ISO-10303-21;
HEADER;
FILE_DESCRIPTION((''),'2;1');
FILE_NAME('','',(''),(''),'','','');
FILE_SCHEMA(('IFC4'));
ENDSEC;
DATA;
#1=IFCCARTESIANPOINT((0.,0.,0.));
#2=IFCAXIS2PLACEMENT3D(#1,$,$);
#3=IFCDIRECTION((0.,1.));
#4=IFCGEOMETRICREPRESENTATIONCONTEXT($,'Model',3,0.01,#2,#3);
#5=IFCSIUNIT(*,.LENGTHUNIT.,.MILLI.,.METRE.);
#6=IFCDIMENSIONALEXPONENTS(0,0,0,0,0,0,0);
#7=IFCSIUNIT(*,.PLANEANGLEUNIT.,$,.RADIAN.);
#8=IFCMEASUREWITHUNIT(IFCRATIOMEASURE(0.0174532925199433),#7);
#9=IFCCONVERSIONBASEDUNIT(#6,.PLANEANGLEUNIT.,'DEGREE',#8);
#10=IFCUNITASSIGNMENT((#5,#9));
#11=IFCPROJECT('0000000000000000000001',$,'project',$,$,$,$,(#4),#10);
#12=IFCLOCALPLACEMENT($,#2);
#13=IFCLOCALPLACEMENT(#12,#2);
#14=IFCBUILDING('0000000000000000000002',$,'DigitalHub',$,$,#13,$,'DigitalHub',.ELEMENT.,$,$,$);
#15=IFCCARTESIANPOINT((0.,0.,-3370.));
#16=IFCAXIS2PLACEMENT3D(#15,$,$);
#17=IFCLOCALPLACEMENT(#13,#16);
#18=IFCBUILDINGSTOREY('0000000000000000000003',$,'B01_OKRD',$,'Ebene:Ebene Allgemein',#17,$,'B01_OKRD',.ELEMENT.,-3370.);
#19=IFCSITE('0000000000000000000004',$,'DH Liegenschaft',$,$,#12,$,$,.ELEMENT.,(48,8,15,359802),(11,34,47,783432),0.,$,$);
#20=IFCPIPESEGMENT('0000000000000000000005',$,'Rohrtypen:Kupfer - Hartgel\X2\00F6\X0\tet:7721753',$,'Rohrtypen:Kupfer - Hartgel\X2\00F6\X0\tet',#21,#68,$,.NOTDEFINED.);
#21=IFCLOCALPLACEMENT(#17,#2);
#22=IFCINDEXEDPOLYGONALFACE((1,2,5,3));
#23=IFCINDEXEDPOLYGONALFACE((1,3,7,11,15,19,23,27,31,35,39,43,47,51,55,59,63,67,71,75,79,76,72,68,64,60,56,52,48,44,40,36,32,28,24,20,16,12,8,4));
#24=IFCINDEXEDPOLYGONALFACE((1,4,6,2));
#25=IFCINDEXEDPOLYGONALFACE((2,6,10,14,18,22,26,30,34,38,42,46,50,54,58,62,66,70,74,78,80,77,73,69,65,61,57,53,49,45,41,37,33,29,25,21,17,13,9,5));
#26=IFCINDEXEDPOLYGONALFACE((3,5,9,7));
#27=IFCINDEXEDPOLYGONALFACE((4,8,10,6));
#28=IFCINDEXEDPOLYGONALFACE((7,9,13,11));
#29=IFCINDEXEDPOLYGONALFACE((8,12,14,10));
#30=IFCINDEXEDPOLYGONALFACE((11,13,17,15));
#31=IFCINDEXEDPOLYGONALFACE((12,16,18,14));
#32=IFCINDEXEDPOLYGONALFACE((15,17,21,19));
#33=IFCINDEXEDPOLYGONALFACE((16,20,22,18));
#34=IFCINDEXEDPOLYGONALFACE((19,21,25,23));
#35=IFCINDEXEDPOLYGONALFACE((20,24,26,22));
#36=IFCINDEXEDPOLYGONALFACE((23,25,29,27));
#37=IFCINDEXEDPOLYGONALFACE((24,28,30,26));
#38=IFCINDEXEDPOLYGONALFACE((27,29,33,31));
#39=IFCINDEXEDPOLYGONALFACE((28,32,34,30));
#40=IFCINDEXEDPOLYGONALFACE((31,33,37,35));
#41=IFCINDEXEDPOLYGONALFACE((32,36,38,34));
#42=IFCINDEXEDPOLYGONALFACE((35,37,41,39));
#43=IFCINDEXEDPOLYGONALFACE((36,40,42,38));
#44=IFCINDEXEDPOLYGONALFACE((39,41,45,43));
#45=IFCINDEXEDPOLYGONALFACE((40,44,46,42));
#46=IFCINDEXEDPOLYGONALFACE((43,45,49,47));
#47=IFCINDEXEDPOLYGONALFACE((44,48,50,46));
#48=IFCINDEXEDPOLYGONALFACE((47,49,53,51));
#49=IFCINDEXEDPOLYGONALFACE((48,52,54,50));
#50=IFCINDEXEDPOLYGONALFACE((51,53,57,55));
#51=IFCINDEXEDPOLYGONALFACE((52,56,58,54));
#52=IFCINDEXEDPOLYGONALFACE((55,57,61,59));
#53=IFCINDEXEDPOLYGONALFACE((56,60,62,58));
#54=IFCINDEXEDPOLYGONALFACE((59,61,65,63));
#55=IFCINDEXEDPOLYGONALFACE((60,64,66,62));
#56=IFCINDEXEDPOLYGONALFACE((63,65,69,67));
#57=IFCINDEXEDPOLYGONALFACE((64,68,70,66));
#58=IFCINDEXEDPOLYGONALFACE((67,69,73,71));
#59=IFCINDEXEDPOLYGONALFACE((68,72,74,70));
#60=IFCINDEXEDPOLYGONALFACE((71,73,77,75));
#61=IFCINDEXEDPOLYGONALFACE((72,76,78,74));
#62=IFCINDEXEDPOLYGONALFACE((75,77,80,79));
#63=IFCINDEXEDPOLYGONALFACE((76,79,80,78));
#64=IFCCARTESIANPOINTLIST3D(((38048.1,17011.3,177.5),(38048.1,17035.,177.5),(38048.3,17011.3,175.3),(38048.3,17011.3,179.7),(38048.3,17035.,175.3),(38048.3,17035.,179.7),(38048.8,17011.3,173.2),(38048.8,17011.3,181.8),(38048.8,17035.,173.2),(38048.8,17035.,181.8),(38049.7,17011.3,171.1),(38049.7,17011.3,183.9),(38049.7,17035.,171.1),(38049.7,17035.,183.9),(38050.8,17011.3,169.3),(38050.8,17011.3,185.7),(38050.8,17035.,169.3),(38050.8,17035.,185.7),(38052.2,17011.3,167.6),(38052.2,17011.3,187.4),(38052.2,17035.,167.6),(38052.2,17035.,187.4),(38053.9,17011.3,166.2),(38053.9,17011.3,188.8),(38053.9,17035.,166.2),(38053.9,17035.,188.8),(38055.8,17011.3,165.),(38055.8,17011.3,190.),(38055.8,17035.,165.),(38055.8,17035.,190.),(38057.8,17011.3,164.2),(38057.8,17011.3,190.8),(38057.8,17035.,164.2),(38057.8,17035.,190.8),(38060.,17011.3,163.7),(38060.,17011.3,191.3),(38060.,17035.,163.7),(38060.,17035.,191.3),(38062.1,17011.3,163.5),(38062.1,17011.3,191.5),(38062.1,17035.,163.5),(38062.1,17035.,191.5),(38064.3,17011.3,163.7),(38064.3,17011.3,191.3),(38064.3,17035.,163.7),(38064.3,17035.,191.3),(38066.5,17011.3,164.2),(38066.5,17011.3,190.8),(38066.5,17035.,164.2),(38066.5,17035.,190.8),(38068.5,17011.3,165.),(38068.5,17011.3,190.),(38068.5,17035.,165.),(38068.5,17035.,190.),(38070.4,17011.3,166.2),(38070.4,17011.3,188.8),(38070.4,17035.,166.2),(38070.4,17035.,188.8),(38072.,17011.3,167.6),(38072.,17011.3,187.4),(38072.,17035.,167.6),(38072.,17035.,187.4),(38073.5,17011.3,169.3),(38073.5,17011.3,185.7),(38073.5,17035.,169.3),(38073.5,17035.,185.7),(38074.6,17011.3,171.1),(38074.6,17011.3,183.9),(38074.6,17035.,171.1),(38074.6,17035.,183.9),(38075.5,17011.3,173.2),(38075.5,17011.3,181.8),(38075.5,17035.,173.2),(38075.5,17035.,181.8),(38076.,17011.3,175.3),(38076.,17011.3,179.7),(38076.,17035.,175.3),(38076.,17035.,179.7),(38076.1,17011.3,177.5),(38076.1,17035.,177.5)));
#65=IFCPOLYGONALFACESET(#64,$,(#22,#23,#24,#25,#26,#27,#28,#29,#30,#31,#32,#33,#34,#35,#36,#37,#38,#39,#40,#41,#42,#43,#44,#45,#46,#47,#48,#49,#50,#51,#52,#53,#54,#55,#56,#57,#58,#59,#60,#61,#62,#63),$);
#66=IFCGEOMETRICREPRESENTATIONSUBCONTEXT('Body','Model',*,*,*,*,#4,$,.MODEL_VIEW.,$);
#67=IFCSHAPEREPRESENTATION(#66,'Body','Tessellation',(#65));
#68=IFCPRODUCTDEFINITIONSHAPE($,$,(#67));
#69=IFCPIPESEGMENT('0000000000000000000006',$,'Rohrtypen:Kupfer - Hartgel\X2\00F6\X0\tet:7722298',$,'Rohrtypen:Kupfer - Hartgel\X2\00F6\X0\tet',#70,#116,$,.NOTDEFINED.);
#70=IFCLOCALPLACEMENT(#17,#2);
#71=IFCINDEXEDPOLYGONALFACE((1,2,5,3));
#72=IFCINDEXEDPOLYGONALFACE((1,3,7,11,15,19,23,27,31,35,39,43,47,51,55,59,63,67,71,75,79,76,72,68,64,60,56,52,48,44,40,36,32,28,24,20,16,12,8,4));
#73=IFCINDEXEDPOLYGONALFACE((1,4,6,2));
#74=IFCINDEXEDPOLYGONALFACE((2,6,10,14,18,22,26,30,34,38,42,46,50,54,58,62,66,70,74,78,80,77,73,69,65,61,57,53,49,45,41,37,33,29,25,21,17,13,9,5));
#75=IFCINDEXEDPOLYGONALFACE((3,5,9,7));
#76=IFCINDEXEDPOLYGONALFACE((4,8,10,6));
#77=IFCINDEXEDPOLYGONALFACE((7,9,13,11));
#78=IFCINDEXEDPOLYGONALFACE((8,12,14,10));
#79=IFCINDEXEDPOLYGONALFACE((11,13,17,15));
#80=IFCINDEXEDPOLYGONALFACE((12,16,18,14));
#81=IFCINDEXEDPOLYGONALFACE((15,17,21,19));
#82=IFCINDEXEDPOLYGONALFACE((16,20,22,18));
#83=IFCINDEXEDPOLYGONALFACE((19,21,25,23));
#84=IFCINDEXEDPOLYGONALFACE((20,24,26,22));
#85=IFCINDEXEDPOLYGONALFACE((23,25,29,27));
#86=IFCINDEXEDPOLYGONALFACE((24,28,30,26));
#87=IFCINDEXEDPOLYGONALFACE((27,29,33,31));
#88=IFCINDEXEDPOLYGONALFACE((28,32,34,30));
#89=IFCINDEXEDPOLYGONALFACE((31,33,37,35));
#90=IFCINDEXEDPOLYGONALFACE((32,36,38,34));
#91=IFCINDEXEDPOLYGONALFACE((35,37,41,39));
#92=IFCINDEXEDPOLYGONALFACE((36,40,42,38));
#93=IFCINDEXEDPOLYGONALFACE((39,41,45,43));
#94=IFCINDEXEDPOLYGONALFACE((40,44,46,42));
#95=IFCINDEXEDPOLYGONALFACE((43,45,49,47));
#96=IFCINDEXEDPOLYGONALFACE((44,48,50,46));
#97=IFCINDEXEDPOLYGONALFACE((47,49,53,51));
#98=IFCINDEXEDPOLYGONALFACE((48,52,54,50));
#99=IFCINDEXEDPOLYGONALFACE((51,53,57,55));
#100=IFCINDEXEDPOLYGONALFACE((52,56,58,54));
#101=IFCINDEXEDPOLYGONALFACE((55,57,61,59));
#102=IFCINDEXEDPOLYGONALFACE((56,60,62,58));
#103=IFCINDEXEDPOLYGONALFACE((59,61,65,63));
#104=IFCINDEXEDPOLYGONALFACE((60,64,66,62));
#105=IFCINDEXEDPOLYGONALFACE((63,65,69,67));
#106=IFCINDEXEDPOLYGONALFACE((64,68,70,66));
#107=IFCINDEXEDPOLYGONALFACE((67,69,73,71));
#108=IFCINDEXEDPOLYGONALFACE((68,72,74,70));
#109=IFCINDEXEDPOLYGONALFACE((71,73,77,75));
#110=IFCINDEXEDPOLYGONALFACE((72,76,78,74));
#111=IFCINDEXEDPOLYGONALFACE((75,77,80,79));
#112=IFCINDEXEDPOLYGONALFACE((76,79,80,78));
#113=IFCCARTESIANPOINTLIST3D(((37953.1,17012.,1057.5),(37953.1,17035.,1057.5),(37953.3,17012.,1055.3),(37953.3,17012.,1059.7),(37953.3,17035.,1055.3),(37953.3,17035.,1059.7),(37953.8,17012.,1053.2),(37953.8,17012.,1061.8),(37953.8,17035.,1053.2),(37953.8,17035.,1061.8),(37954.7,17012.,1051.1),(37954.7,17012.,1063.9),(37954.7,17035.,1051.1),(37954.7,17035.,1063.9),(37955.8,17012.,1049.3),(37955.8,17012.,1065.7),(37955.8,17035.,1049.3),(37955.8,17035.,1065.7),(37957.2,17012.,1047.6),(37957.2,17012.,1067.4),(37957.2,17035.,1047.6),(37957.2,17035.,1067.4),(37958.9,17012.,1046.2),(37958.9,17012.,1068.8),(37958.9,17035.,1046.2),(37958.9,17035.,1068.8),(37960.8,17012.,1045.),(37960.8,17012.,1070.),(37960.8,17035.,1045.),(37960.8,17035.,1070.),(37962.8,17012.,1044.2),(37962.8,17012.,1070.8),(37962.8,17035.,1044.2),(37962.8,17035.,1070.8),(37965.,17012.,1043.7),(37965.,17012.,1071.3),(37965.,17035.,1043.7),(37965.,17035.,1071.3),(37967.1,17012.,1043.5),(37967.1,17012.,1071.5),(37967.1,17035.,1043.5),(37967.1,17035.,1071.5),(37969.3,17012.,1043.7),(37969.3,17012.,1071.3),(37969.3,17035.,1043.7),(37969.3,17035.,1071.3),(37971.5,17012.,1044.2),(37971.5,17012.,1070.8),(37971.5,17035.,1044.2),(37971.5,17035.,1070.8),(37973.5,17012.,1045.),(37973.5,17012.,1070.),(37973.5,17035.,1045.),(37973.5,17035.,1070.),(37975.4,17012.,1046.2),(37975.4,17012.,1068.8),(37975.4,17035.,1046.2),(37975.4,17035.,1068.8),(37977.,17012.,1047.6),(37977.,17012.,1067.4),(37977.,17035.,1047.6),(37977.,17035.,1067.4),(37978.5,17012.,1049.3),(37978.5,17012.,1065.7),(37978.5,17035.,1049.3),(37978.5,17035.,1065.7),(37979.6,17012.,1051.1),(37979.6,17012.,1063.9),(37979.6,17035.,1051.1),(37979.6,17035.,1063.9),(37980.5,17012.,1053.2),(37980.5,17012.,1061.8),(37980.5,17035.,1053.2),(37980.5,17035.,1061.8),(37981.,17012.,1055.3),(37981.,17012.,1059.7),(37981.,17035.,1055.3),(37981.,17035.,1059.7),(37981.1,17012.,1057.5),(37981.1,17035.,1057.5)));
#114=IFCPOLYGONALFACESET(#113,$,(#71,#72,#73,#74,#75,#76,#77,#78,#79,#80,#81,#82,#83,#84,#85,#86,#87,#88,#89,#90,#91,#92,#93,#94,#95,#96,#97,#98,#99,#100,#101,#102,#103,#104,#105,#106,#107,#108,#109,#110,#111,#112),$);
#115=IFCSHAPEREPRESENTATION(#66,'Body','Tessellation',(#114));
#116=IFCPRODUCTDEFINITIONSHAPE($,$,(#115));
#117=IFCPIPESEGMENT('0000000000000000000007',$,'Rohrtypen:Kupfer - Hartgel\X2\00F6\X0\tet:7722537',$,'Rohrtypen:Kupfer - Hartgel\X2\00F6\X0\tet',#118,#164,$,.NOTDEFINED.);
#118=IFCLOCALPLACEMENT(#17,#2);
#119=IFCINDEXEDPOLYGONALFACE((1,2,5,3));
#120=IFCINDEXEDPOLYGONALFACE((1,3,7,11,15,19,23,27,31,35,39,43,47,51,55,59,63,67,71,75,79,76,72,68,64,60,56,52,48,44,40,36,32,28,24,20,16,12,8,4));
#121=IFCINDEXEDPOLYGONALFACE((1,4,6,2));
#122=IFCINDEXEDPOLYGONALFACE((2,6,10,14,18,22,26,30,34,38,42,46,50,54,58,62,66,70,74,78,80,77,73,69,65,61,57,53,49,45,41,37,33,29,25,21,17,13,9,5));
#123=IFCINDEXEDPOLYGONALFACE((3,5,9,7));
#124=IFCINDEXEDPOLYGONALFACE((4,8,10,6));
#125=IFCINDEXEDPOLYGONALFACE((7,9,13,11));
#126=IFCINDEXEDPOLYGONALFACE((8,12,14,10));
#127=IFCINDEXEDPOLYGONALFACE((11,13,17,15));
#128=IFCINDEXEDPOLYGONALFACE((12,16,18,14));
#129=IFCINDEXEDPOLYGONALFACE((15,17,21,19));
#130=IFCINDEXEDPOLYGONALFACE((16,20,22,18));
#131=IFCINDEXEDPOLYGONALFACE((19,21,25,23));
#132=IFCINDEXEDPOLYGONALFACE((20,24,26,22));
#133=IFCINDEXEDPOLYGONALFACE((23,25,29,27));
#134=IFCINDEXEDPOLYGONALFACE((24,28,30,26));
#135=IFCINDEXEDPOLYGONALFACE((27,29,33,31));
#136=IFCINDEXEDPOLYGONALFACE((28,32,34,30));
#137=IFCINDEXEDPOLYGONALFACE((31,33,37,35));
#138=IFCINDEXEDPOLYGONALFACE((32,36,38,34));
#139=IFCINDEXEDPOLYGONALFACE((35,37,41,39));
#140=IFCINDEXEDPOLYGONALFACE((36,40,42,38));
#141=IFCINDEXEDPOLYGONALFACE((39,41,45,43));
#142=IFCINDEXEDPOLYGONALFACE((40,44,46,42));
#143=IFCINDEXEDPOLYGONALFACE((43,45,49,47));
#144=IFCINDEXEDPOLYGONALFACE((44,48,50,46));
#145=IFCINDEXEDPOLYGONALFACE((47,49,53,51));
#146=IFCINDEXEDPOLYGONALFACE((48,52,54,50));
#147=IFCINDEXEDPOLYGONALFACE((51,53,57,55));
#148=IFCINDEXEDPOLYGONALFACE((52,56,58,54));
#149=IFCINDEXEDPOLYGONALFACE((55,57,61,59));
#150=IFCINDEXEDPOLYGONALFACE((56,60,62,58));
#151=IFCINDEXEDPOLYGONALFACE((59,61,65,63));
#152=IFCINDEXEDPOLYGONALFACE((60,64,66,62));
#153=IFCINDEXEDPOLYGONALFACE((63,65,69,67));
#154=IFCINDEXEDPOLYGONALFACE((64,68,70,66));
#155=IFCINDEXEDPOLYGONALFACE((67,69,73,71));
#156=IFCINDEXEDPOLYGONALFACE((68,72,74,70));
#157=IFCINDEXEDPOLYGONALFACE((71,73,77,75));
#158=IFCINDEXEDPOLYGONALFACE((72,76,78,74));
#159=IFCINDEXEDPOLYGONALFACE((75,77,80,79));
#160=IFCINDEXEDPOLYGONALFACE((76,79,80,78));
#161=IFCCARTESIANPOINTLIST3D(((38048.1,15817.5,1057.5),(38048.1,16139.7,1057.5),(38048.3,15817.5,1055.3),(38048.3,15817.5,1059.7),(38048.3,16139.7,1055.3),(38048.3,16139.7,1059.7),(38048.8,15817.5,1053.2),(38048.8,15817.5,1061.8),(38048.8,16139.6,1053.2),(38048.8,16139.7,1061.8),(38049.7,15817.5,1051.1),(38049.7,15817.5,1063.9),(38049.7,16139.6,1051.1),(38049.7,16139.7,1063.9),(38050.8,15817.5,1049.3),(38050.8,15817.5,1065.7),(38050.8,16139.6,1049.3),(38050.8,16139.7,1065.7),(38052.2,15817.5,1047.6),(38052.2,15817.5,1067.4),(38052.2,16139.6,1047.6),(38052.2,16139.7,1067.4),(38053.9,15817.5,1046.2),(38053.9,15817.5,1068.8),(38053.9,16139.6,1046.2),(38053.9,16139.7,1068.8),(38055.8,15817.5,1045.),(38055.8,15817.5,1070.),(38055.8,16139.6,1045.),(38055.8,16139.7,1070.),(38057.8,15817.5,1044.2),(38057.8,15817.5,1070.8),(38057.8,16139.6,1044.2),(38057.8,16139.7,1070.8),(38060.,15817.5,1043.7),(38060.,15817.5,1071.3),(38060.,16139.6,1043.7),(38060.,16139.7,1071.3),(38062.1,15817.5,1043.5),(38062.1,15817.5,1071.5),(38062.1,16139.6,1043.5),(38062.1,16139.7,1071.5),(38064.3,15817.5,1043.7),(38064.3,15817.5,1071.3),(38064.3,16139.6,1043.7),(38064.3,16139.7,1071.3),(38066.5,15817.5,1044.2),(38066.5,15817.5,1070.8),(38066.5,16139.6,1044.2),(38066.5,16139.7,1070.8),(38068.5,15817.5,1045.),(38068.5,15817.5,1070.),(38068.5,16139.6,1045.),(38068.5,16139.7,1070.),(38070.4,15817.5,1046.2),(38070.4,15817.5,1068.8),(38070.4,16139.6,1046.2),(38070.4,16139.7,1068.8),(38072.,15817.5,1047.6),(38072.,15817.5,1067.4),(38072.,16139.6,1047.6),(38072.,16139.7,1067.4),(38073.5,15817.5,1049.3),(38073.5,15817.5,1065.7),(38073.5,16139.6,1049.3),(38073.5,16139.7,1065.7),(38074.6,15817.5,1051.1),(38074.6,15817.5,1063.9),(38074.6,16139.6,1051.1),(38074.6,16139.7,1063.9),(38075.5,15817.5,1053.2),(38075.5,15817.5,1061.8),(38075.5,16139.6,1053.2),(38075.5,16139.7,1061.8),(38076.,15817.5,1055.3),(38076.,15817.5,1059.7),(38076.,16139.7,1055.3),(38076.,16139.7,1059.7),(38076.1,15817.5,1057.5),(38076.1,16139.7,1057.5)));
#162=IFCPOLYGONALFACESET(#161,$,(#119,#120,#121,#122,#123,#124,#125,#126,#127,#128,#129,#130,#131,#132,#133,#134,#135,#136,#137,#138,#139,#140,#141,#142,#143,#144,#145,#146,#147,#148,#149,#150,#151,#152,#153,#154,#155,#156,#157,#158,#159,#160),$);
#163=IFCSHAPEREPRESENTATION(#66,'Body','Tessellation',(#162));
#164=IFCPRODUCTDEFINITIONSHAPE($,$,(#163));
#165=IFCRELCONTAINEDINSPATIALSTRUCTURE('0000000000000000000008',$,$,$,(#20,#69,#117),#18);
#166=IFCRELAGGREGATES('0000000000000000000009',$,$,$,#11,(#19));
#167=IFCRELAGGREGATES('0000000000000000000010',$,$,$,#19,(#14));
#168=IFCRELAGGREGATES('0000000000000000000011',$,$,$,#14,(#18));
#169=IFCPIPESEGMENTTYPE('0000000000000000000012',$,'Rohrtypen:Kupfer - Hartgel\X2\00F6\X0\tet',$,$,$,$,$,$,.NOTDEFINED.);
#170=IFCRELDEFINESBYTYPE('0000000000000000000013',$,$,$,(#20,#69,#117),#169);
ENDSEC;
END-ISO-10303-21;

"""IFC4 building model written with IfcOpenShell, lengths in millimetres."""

from ifc_helpers import new_model, entity, si_unit, converted_unit, direction, frame, origin, place, context, subcontext, project, spatial, indexed_curve, outline, extrude, type_object, element, save


model = new_model("IFC4")

# Units and contexts
model_context = context("Model", 3, precision=0.01, world=origin(), true_north=direction((0.0, 1.0)))
body_context = subcontext(model_context, "Body", "Model", "MODEL_VIEW")
ifc_project = project(units=[si_unit("LENGTHUNIT", "METRE", prefix="MILLI"), converted_unit("PLANEANGLEUNIT", "DEGREE", entity("IfcRatioMeasure", 0.0174532925199433), si_unit("PLANEANGLEUNIT", "RADIAN"), dimensions=[0, 0, 0, 0, 0, 0, 0])], contexts=[model_context])

# Site, building, storey
site_placement = place(None, origin())
site = spatial("IfcSite", under=ifc_project, at=site_placement, Name="DH Liegenschaft", CompositionType="ELEMENT", RefLatitude=(48, 8, 15, 359802), RefLongitude=(11, 34, 47, 783432), RefElevation=0.0)
building_placement = place(site_placement, origin())
building = spatial("IfcBuilding", under=site, at=building_placement, Name="DigitalHub", LongName="DigitalHub", CompositionType="ELEMENT")
storey_placement = place(building_placement, frame((0.0, 0.0, -3370.0)))
storey = spatial("IfcBuildingStorey", under=building, at=storey_placement, Name="B01_OKRD", ObjectType="Ebene:Ebene Allgemein", LongName="B01_OKRD", CompositionType="ELEMENT", Elevation=-3370.0)

# Pipe segments
pipe_segment_type = type_object("IfcPipeSegmentType", Name="Rohrtypen:Kupfer - Hartgelötet", PredefinedType="NOTDEFINED")
pipe_segment_1_placement = place(storey_placement, frame((38046.6, 17011.3, 161.9)))
element("IfcPipeSegment", 1, at=pipe_segment_1_placement, inside=storey, type_object=pipe_segment_type, Name="Rohrtypen:Kupfer - Hartgelötet:7721753", ObjectType="Rohrtypen:Kupfer - Hartgelötet", PredefinedType="NOTDEFINED", context=body_context, shape_type="SweptSolid", body=[
    extrude(outline(indexed_curve([(14.0, 0.0), (13.8, 2.2), (13.3, 4.3), (12.5, 6.4), (11.3, 8.2), (9.9, 9.9), (8.2, 11.3), (6.4, 12.5), (4.3, 13.3), (2.2, 13.8), (0.0, 14.0), (-2.2, 13.8), (-4.3, 13.3), (-6.4, 12.5), (-8.2, 11.3), (-9.9, 9.9), (-11.3, 8.2), (-12.5, 6.4), (-13.3, 4.3), (-13.8, 2.2), (-14.0, 0.0), (-13.8, -2.2), (-13.3, -4.3), (-12.5, -6.4), (-11.3, -8.2), (-9.9, -9.9), (-8.2, -11.3), (-6.4, -12.5), (-4.3, -13.3), (-2.2, -13.8), (0.0, -14.0), (2.2, -13.8), (4.3, -13.3), (6.4, -12.5), (8.2, -11.3), (9.9, -9.9), (11.3, -8.2), (12.5, -6.4), (13.3, -4.3), (13.8, -2.2), (14.0, 0.0)], self_intersect=False)), frame((15.6, 0.0, 15.6), z_axis=(0.0, 1.0, 0.0), x_axis=(-1.0, 0.0, 0.0)), (0.0, 0.0, 1.0), 23.7),
])
pipe_segment_2_placement = place(storey_placement, frame((37951.6, 17012.0, 1041.9)))
element("IfcPipeSegment", 2, at=pipe_segment_2_placement, inside=storey, type_object=pipe_segment_type, Name="Rohrtypen:Kupfer - Hartgelötet:7722298", ObjectType="Rohrtypen:Kupfer - Hartgelötet", PredefinedType="NOTDEFINED", context=body_context, shape_type="SweptSolid", body=[
    extrude(outline(indexed_curve([(14.0, 0.0), (13.8, 2.2), (13.3, 4.3), (12.5, 6.4), (11.3, 8.2), (9.9, 9.9), (8.2, 11.3), (6.4, 12.5), (4.3, 13.3), (2.2, 13.8), (0.0, 14.0), (-2.2, 13.8), (-4.3, 13.3), (-6.4, 12.5), (-8.2, 11.3), (-9.9, 9.9), (-11.3, 8.2), (-12.5, 6.4), (-13.3, 4.3), (-13.8, 2.2), (-14.0, 0.0), (-13.8, -2.2), (-13.3, -4.3), (-12.5, -6.4), (-11.3, -8.2), (-9.9, -9.9), (-8.2, -11.3), (-6.4, -12.5), (-4.3, -13.3), (-2.2, -13.8), (0.0, -14.0), (2.2, -13.8), (4.3, -13.3), (6.4, -12.5), (8.2, -11.3), (9.9, -9.9), (11.3, -8.2), (12.5, -6.4), (13.3, -4.3), (13.8, -2.2), (14.0, 0.0)], self_intersect=False)), frame((15.6, 0.0, 15.6), z_axis=(0.0, 1.0, 0.0), x_axis=(-1.0, 0.0, 0.0)), (0.0, 0.0, 1.0), 23.0),
])
pipe_segment_3_placement = place(storey_placement, frame((38046.6, 15817.5, 1041.9)))
element("IfcPipeSegment", 3, at=pipe_segment_3_placement, inside=storey, type_object=pipe_segment_type, Name="Rohrtypen:Kupfer - Hartgelötet:7722537", ObjectType="Rohrtypen:Kupfer - Hartgelötet", PredefinedType="NOTDEFINED", context=body_context, shape_type="SweptSolid", body=[
    extrude(outline(indexed_curve([(14.0, 0.0), (13.8, 2.2), (13.3, 4.3), (12.5, 6.4), (11.3, 8.2), (9.9, 9.9), (8.2, 11.3), (6.4, 12.5), (4.3, 13.3), (2.2, 13.8), (0.0, 14.0), (-2.2, 13.8), (-4.3, 13.3), (-6.4, 12.5), (-8.2, 11.3), (-9.9, 9.9), (-11.3, 8.2), (-12.5, 6.4), (-13.3, 4.3), (-13.8, 2.2), (-14.0, 0.0), (-13.8, -2.2), (-13.3, -4.3), (-12.5, -6.4), (-11.3, -8.2), (-9.9, -9.9), (-8.2, -11.3), (-6.4, -12.5), (-4.3, -13.3), (-2.2, -13.8), (0.0, -14.0), (2.2, -13.8), (4.3, -13.3), (6.4, -12.5), (8.2, -11.3), (9.9, -9.9), (11.3, -8.2), (12.5, -6.4), (13.3, -4.3), (13.8, -2.2), (14.0, 0.0)], self_intersect=False)), frame((15.6, 322.2, 15.6), z_axis=(0.0, -1.0, 0.000012), x_axis=(1.0, 0.0, 0.0)), (0.0, 0.0, 1.0), 322.2),
])

save(model, "model.ifc")
